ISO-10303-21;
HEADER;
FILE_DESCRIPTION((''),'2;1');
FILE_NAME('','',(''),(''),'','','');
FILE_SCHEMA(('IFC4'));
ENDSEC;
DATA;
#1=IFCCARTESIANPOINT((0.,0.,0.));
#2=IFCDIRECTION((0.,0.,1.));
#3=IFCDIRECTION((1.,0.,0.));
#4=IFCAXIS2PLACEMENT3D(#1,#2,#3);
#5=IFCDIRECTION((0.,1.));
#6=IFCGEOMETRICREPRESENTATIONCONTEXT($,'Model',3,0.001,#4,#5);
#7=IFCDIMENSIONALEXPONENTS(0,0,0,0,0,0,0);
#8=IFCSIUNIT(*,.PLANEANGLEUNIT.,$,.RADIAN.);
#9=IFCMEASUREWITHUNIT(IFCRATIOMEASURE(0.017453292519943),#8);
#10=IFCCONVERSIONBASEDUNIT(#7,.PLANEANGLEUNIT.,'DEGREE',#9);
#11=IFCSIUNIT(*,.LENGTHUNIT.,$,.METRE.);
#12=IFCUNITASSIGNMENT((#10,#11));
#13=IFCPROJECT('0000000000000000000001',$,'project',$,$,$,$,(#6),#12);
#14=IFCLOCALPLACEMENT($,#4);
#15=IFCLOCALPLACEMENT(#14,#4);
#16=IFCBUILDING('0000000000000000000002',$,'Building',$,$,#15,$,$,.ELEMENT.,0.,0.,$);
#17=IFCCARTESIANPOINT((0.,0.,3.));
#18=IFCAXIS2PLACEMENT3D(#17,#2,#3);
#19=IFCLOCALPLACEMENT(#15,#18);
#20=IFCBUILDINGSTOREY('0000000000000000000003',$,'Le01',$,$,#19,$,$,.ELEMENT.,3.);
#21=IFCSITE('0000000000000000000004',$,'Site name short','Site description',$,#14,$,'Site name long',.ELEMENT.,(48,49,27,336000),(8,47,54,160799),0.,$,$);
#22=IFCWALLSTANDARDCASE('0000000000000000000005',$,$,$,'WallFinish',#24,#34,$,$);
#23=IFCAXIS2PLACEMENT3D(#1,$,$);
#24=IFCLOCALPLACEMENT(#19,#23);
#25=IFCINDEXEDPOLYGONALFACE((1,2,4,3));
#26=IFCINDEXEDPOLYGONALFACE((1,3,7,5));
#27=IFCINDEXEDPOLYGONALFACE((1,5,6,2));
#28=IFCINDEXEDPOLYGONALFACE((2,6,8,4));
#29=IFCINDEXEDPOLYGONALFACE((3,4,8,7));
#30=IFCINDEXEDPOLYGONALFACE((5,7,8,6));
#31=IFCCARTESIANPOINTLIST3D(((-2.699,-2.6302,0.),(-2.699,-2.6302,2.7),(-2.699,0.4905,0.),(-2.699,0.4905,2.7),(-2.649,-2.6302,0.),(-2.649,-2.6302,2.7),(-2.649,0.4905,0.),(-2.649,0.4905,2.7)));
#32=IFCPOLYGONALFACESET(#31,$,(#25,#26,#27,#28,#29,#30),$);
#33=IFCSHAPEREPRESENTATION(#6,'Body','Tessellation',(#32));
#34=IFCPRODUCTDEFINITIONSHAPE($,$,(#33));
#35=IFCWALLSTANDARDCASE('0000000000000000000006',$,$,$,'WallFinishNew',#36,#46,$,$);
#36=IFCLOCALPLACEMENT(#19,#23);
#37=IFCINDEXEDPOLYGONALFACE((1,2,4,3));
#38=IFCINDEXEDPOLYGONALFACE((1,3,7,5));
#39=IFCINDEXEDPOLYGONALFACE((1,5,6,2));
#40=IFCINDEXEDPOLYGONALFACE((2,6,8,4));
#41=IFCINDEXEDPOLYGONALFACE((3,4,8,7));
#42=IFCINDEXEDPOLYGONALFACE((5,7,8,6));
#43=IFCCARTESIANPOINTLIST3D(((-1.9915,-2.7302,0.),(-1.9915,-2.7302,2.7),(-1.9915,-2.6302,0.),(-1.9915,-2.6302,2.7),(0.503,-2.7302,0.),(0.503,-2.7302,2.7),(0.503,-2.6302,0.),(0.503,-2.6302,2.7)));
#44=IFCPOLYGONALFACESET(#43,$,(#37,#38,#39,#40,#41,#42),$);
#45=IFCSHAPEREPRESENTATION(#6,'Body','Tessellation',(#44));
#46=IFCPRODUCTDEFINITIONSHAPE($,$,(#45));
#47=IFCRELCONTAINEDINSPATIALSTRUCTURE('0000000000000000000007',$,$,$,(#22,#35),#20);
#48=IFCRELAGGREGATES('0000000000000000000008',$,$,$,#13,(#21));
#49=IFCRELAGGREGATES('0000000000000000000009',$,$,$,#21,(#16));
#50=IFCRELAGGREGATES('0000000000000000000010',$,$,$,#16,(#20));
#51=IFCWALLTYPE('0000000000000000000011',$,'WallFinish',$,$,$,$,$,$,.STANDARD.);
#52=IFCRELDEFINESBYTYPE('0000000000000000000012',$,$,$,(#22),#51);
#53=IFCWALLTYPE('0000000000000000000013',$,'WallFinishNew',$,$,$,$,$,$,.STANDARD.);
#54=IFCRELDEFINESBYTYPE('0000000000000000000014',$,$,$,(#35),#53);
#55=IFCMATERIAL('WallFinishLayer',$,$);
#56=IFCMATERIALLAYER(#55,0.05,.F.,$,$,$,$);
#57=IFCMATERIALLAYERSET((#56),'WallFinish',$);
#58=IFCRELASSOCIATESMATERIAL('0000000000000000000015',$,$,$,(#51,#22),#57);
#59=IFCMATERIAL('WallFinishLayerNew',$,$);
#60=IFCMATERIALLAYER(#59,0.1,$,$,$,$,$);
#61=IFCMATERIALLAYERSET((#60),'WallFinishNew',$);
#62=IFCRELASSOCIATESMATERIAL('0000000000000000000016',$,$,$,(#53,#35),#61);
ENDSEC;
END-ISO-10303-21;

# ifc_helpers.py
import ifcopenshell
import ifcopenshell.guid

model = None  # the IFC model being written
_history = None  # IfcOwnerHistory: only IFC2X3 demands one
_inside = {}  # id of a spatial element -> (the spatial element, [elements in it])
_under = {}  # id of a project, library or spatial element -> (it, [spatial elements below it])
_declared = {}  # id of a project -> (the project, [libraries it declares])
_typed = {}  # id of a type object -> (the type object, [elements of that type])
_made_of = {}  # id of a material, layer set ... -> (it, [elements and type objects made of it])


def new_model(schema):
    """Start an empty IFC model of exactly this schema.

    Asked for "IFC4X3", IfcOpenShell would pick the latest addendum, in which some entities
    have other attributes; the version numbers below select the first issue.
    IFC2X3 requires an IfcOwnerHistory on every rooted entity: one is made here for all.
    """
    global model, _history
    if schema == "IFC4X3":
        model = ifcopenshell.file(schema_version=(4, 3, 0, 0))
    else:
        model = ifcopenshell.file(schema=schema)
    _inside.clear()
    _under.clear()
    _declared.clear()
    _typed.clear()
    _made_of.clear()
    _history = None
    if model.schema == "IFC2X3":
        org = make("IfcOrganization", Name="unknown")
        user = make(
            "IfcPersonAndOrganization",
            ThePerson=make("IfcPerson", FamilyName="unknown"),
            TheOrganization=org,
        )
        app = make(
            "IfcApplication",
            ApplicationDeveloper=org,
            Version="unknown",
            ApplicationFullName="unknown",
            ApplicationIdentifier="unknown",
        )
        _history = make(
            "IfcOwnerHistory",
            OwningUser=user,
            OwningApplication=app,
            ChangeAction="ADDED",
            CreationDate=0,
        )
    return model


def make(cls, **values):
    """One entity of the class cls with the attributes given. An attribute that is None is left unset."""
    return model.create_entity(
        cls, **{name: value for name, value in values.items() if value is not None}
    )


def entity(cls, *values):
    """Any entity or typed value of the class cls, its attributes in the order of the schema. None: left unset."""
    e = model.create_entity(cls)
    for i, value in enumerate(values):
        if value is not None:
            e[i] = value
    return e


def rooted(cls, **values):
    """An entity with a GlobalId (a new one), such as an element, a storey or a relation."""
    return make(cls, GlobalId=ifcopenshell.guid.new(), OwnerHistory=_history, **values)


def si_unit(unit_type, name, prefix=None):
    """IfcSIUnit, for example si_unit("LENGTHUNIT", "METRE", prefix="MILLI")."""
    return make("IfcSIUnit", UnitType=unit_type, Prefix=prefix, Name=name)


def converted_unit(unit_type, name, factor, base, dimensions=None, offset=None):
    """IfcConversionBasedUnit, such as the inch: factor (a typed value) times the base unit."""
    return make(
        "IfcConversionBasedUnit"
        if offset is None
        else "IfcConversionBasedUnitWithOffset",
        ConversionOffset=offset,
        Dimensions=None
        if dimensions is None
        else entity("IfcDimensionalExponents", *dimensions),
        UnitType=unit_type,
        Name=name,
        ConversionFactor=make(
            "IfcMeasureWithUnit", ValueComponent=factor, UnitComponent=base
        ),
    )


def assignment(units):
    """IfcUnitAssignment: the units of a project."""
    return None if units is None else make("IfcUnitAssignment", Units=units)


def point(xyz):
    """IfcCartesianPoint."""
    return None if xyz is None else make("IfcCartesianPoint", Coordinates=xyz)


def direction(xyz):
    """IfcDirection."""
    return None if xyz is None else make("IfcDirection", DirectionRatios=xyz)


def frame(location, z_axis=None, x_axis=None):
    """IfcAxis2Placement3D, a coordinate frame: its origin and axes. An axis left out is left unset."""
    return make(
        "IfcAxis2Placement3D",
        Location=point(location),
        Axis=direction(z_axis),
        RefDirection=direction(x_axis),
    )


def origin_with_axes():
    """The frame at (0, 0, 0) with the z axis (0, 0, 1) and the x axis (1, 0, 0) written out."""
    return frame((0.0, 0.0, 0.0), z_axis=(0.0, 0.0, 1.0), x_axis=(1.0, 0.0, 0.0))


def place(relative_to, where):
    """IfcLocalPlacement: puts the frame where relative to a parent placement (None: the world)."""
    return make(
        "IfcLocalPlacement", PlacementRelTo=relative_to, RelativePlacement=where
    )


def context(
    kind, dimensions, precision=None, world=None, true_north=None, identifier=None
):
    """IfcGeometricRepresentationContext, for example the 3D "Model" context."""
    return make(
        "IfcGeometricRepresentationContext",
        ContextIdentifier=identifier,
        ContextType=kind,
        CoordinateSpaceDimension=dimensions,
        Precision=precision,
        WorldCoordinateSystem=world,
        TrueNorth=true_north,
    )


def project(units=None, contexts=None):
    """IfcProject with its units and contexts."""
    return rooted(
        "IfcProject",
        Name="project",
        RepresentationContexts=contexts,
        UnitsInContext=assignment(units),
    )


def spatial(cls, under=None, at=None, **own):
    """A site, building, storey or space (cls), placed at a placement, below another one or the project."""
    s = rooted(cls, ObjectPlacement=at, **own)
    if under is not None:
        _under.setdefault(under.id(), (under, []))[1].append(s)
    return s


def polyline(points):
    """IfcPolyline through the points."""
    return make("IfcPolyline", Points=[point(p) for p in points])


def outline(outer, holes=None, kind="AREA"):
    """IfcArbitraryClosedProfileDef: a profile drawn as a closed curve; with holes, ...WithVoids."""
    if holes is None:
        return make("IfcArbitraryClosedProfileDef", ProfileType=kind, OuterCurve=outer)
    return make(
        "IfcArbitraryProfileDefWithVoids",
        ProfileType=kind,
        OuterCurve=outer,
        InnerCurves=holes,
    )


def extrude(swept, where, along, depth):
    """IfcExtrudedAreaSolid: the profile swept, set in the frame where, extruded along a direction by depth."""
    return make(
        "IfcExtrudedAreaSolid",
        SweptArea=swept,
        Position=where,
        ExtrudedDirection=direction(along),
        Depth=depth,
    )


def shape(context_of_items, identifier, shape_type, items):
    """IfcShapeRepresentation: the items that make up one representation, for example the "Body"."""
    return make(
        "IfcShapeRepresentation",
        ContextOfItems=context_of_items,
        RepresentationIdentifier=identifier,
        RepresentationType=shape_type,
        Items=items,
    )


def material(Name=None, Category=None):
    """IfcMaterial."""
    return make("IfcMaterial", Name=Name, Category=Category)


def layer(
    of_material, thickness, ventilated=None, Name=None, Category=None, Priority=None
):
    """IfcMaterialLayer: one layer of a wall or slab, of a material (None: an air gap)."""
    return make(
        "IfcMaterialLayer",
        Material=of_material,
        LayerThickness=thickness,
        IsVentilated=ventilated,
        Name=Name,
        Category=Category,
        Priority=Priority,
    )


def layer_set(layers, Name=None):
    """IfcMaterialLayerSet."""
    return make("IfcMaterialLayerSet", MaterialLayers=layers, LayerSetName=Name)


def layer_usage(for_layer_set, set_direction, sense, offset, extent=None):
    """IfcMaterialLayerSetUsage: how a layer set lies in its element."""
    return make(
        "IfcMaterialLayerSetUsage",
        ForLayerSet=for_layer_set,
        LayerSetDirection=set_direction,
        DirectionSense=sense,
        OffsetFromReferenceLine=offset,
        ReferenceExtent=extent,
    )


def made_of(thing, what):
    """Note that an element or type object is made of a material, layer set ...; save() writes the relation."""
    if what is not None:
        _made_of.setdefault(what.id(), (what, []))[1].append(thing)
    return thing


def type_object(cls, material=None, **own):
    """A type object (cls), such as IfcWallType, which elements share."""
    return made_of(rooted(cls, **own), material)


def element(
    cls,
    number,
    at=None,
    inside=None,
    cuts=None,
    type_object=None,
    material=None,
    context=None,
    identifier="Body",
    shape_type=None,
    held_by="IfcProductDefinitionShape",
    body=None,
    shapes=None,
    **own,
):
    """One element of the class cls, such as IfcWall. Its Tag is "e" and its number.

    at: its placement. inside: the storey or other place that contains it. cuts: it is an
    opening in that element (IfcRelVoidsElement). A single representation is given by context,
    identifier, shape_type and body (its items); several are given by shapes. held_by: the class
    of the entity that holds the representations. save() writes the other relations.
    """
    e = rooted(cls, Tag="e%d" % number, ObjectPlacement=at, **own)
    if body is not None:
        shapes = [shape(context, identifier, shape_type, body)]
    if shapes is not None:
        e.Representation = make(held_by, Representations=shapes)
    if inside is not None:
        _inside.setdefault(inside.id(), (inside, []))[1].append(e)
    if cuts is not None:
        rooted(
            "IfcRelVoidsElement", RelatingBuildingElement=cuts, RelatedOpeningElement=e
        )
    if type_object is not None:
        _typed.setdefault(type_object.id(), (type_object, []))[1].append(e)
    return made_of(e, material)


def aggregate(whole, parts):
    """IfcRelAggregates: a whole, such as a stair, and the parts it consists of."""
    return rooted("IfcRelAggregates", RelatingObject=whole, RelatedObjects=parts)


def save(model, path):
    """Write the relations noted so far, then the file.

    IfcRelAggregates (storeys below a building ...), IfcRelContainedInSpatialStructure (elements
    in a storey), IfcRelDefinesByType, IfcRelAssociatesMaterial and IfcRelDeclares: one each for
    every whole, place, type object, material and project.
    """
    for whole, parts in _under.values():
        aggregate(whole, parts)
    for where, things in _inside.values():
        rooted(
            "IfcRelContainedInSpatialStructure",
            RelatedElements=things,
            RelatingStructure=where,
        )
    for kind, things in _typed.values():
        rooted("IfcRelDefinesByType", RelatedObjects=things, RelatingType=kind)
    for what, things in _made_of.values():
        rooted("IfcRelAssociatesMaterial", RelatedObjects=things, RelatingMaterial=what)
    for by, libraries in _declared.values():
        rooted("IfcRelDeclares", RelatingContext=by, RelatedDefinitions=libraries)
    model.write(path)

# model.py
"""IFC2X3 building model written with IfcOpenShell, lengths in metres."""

from ifc_helpers import new_model, entity, si_unit, converted_unit, direction, frame, origin_with_axes, place, context, project, spatial, polyline, outline, extrude, material, layer, layer_set, layer_usage, type_object, element, save


model = new_model("IFC2X3")

# Units and contexts
model_context = context("Model", 3, precision=0.001, world=origin_with_axes(), true_north=direction((0.0, 1.0)))
ifc_project = project(units=[converted_unit("PLANEANGLEUNIT", "DEGREE", entity("IfcRatioMeasure", 0.017453292519943), si_unit("PLANEANGLEUNIT", "RADIAN"), dimensions=[0, 0, 0, 0, 0, 0, 0]), si_unit("LENGTHUNIT", "METRE")], contexts=[model_context])

# Site, building, storey
site_placement = place(None, origin_with_axes())
site = spatial("IfcSite", under=ifc_project, at=site_placement, Name="Site name short", Description="Site description", LongName="Site name long", CompositionType="ELEMENT", RefLatitude=(48, 49, 27, 336000), RefLongitude=(8, 47, 54, 160799), RefElevation=0.0)
building_placement = place(site_placement, origin_with_axes())
building = spatial("IfcBuilding", under=site, at=building_placement, Name="Building", CompositionType="ELEMENT", ElevationOfRefHeight=0.0, ElevationOfTerrain=0.0)
storey_placement = place(building_placement, frame((0.0, 0.0, 3.0), z_axis=(0.0, 0.0, 1.0), x_axis=(1.0, 0.0, 0.0)))
storey = spatial("IfcBuildingStorey", under=building, at=storey_placement, Name="Le01", CompositionType="ELEMENT", Elevation=3.0)

# Walls
ifc_material_1 = material(Name="WallFinishLayer")
ifc_layer_1 = layer(ifc_material_1, 0.05, ventilated=False)
ifc_layer_set_1 = layer_set([ifc_layer_1], Name="WallFinish")
ifc_layer_usage_1 = layer_usage(ifc_layer_set_1, "AXIS2", "POSITIVE", -0.025)
wall_type_1 = type_object("IfcWallType", Name="WallFinish", PredefinedType="STANDARD", material=ifc_layer_set_1)
wall_1_placement = place(site_placement, frame((-2.699, -2.6302, 3.0), z_axis=(0.0, 0.0, 1.0), x_axis=(0.0, 1.0, 0.0)))
element("IfcWallStandardCase", 1, at=wall_1_placement, inside=storey, type_object=wall_type_1, material=ifc_layer_usage_1, ObjectType="WallFinish", context=model_context, shape_type="SweptSolid", body=[
    extrude(outline(polyline([(3.1207, -0.05), (3.1207, 0.0), (0.0, 0.0), (0.0, -0.05), (3.1207, -0.05)])), origin_with_axes(), (0.0, 0.0, 1.0), 2.7),
])
ifc_material_2 = material(Name="WallFinishLayerNew")
ifc_layer_2 = layer(ifc_material_2, 0.1)
ifc_layer_set_2 = layer_set([ifc_layer_2], Name="WallFinishNew")
ifc_layer_usage_2 = layer_usage(ifc_layer_set_2, "AXIS2", "POSITIVE", -0.05)
wall_type_2 = type_object("IfcWallType", Name="WallFinishNew", PredefinedType="STANDARD", material=ifc_layer_set_2)
wall_2_placement = place(site_placement, frame((-1.9915, -2.6302, 3.0), z_axis=(0.0, 0.0, 1.0), x_axis=(1.0, 0.0, 0.0)))
element("IfcWallStandardCase", 2, at=wall_2_placement, inside=storey, type_object=wall_type_2, material=ifc_layer_usage_2, ObjectType="WallFinishNew", context=model_context, shape_type="SweptSolid", body=[
    extrude(outline(polyline([(2.4945, -0.1), (2.4945, 0.0), (0.0, 0.0), (0.0, -0.1), (2.4945, -0.1)])), origin_with_axes(), (0.0, 0.0, 1.0), 2.7),
])

save(model, "model.ifc")
